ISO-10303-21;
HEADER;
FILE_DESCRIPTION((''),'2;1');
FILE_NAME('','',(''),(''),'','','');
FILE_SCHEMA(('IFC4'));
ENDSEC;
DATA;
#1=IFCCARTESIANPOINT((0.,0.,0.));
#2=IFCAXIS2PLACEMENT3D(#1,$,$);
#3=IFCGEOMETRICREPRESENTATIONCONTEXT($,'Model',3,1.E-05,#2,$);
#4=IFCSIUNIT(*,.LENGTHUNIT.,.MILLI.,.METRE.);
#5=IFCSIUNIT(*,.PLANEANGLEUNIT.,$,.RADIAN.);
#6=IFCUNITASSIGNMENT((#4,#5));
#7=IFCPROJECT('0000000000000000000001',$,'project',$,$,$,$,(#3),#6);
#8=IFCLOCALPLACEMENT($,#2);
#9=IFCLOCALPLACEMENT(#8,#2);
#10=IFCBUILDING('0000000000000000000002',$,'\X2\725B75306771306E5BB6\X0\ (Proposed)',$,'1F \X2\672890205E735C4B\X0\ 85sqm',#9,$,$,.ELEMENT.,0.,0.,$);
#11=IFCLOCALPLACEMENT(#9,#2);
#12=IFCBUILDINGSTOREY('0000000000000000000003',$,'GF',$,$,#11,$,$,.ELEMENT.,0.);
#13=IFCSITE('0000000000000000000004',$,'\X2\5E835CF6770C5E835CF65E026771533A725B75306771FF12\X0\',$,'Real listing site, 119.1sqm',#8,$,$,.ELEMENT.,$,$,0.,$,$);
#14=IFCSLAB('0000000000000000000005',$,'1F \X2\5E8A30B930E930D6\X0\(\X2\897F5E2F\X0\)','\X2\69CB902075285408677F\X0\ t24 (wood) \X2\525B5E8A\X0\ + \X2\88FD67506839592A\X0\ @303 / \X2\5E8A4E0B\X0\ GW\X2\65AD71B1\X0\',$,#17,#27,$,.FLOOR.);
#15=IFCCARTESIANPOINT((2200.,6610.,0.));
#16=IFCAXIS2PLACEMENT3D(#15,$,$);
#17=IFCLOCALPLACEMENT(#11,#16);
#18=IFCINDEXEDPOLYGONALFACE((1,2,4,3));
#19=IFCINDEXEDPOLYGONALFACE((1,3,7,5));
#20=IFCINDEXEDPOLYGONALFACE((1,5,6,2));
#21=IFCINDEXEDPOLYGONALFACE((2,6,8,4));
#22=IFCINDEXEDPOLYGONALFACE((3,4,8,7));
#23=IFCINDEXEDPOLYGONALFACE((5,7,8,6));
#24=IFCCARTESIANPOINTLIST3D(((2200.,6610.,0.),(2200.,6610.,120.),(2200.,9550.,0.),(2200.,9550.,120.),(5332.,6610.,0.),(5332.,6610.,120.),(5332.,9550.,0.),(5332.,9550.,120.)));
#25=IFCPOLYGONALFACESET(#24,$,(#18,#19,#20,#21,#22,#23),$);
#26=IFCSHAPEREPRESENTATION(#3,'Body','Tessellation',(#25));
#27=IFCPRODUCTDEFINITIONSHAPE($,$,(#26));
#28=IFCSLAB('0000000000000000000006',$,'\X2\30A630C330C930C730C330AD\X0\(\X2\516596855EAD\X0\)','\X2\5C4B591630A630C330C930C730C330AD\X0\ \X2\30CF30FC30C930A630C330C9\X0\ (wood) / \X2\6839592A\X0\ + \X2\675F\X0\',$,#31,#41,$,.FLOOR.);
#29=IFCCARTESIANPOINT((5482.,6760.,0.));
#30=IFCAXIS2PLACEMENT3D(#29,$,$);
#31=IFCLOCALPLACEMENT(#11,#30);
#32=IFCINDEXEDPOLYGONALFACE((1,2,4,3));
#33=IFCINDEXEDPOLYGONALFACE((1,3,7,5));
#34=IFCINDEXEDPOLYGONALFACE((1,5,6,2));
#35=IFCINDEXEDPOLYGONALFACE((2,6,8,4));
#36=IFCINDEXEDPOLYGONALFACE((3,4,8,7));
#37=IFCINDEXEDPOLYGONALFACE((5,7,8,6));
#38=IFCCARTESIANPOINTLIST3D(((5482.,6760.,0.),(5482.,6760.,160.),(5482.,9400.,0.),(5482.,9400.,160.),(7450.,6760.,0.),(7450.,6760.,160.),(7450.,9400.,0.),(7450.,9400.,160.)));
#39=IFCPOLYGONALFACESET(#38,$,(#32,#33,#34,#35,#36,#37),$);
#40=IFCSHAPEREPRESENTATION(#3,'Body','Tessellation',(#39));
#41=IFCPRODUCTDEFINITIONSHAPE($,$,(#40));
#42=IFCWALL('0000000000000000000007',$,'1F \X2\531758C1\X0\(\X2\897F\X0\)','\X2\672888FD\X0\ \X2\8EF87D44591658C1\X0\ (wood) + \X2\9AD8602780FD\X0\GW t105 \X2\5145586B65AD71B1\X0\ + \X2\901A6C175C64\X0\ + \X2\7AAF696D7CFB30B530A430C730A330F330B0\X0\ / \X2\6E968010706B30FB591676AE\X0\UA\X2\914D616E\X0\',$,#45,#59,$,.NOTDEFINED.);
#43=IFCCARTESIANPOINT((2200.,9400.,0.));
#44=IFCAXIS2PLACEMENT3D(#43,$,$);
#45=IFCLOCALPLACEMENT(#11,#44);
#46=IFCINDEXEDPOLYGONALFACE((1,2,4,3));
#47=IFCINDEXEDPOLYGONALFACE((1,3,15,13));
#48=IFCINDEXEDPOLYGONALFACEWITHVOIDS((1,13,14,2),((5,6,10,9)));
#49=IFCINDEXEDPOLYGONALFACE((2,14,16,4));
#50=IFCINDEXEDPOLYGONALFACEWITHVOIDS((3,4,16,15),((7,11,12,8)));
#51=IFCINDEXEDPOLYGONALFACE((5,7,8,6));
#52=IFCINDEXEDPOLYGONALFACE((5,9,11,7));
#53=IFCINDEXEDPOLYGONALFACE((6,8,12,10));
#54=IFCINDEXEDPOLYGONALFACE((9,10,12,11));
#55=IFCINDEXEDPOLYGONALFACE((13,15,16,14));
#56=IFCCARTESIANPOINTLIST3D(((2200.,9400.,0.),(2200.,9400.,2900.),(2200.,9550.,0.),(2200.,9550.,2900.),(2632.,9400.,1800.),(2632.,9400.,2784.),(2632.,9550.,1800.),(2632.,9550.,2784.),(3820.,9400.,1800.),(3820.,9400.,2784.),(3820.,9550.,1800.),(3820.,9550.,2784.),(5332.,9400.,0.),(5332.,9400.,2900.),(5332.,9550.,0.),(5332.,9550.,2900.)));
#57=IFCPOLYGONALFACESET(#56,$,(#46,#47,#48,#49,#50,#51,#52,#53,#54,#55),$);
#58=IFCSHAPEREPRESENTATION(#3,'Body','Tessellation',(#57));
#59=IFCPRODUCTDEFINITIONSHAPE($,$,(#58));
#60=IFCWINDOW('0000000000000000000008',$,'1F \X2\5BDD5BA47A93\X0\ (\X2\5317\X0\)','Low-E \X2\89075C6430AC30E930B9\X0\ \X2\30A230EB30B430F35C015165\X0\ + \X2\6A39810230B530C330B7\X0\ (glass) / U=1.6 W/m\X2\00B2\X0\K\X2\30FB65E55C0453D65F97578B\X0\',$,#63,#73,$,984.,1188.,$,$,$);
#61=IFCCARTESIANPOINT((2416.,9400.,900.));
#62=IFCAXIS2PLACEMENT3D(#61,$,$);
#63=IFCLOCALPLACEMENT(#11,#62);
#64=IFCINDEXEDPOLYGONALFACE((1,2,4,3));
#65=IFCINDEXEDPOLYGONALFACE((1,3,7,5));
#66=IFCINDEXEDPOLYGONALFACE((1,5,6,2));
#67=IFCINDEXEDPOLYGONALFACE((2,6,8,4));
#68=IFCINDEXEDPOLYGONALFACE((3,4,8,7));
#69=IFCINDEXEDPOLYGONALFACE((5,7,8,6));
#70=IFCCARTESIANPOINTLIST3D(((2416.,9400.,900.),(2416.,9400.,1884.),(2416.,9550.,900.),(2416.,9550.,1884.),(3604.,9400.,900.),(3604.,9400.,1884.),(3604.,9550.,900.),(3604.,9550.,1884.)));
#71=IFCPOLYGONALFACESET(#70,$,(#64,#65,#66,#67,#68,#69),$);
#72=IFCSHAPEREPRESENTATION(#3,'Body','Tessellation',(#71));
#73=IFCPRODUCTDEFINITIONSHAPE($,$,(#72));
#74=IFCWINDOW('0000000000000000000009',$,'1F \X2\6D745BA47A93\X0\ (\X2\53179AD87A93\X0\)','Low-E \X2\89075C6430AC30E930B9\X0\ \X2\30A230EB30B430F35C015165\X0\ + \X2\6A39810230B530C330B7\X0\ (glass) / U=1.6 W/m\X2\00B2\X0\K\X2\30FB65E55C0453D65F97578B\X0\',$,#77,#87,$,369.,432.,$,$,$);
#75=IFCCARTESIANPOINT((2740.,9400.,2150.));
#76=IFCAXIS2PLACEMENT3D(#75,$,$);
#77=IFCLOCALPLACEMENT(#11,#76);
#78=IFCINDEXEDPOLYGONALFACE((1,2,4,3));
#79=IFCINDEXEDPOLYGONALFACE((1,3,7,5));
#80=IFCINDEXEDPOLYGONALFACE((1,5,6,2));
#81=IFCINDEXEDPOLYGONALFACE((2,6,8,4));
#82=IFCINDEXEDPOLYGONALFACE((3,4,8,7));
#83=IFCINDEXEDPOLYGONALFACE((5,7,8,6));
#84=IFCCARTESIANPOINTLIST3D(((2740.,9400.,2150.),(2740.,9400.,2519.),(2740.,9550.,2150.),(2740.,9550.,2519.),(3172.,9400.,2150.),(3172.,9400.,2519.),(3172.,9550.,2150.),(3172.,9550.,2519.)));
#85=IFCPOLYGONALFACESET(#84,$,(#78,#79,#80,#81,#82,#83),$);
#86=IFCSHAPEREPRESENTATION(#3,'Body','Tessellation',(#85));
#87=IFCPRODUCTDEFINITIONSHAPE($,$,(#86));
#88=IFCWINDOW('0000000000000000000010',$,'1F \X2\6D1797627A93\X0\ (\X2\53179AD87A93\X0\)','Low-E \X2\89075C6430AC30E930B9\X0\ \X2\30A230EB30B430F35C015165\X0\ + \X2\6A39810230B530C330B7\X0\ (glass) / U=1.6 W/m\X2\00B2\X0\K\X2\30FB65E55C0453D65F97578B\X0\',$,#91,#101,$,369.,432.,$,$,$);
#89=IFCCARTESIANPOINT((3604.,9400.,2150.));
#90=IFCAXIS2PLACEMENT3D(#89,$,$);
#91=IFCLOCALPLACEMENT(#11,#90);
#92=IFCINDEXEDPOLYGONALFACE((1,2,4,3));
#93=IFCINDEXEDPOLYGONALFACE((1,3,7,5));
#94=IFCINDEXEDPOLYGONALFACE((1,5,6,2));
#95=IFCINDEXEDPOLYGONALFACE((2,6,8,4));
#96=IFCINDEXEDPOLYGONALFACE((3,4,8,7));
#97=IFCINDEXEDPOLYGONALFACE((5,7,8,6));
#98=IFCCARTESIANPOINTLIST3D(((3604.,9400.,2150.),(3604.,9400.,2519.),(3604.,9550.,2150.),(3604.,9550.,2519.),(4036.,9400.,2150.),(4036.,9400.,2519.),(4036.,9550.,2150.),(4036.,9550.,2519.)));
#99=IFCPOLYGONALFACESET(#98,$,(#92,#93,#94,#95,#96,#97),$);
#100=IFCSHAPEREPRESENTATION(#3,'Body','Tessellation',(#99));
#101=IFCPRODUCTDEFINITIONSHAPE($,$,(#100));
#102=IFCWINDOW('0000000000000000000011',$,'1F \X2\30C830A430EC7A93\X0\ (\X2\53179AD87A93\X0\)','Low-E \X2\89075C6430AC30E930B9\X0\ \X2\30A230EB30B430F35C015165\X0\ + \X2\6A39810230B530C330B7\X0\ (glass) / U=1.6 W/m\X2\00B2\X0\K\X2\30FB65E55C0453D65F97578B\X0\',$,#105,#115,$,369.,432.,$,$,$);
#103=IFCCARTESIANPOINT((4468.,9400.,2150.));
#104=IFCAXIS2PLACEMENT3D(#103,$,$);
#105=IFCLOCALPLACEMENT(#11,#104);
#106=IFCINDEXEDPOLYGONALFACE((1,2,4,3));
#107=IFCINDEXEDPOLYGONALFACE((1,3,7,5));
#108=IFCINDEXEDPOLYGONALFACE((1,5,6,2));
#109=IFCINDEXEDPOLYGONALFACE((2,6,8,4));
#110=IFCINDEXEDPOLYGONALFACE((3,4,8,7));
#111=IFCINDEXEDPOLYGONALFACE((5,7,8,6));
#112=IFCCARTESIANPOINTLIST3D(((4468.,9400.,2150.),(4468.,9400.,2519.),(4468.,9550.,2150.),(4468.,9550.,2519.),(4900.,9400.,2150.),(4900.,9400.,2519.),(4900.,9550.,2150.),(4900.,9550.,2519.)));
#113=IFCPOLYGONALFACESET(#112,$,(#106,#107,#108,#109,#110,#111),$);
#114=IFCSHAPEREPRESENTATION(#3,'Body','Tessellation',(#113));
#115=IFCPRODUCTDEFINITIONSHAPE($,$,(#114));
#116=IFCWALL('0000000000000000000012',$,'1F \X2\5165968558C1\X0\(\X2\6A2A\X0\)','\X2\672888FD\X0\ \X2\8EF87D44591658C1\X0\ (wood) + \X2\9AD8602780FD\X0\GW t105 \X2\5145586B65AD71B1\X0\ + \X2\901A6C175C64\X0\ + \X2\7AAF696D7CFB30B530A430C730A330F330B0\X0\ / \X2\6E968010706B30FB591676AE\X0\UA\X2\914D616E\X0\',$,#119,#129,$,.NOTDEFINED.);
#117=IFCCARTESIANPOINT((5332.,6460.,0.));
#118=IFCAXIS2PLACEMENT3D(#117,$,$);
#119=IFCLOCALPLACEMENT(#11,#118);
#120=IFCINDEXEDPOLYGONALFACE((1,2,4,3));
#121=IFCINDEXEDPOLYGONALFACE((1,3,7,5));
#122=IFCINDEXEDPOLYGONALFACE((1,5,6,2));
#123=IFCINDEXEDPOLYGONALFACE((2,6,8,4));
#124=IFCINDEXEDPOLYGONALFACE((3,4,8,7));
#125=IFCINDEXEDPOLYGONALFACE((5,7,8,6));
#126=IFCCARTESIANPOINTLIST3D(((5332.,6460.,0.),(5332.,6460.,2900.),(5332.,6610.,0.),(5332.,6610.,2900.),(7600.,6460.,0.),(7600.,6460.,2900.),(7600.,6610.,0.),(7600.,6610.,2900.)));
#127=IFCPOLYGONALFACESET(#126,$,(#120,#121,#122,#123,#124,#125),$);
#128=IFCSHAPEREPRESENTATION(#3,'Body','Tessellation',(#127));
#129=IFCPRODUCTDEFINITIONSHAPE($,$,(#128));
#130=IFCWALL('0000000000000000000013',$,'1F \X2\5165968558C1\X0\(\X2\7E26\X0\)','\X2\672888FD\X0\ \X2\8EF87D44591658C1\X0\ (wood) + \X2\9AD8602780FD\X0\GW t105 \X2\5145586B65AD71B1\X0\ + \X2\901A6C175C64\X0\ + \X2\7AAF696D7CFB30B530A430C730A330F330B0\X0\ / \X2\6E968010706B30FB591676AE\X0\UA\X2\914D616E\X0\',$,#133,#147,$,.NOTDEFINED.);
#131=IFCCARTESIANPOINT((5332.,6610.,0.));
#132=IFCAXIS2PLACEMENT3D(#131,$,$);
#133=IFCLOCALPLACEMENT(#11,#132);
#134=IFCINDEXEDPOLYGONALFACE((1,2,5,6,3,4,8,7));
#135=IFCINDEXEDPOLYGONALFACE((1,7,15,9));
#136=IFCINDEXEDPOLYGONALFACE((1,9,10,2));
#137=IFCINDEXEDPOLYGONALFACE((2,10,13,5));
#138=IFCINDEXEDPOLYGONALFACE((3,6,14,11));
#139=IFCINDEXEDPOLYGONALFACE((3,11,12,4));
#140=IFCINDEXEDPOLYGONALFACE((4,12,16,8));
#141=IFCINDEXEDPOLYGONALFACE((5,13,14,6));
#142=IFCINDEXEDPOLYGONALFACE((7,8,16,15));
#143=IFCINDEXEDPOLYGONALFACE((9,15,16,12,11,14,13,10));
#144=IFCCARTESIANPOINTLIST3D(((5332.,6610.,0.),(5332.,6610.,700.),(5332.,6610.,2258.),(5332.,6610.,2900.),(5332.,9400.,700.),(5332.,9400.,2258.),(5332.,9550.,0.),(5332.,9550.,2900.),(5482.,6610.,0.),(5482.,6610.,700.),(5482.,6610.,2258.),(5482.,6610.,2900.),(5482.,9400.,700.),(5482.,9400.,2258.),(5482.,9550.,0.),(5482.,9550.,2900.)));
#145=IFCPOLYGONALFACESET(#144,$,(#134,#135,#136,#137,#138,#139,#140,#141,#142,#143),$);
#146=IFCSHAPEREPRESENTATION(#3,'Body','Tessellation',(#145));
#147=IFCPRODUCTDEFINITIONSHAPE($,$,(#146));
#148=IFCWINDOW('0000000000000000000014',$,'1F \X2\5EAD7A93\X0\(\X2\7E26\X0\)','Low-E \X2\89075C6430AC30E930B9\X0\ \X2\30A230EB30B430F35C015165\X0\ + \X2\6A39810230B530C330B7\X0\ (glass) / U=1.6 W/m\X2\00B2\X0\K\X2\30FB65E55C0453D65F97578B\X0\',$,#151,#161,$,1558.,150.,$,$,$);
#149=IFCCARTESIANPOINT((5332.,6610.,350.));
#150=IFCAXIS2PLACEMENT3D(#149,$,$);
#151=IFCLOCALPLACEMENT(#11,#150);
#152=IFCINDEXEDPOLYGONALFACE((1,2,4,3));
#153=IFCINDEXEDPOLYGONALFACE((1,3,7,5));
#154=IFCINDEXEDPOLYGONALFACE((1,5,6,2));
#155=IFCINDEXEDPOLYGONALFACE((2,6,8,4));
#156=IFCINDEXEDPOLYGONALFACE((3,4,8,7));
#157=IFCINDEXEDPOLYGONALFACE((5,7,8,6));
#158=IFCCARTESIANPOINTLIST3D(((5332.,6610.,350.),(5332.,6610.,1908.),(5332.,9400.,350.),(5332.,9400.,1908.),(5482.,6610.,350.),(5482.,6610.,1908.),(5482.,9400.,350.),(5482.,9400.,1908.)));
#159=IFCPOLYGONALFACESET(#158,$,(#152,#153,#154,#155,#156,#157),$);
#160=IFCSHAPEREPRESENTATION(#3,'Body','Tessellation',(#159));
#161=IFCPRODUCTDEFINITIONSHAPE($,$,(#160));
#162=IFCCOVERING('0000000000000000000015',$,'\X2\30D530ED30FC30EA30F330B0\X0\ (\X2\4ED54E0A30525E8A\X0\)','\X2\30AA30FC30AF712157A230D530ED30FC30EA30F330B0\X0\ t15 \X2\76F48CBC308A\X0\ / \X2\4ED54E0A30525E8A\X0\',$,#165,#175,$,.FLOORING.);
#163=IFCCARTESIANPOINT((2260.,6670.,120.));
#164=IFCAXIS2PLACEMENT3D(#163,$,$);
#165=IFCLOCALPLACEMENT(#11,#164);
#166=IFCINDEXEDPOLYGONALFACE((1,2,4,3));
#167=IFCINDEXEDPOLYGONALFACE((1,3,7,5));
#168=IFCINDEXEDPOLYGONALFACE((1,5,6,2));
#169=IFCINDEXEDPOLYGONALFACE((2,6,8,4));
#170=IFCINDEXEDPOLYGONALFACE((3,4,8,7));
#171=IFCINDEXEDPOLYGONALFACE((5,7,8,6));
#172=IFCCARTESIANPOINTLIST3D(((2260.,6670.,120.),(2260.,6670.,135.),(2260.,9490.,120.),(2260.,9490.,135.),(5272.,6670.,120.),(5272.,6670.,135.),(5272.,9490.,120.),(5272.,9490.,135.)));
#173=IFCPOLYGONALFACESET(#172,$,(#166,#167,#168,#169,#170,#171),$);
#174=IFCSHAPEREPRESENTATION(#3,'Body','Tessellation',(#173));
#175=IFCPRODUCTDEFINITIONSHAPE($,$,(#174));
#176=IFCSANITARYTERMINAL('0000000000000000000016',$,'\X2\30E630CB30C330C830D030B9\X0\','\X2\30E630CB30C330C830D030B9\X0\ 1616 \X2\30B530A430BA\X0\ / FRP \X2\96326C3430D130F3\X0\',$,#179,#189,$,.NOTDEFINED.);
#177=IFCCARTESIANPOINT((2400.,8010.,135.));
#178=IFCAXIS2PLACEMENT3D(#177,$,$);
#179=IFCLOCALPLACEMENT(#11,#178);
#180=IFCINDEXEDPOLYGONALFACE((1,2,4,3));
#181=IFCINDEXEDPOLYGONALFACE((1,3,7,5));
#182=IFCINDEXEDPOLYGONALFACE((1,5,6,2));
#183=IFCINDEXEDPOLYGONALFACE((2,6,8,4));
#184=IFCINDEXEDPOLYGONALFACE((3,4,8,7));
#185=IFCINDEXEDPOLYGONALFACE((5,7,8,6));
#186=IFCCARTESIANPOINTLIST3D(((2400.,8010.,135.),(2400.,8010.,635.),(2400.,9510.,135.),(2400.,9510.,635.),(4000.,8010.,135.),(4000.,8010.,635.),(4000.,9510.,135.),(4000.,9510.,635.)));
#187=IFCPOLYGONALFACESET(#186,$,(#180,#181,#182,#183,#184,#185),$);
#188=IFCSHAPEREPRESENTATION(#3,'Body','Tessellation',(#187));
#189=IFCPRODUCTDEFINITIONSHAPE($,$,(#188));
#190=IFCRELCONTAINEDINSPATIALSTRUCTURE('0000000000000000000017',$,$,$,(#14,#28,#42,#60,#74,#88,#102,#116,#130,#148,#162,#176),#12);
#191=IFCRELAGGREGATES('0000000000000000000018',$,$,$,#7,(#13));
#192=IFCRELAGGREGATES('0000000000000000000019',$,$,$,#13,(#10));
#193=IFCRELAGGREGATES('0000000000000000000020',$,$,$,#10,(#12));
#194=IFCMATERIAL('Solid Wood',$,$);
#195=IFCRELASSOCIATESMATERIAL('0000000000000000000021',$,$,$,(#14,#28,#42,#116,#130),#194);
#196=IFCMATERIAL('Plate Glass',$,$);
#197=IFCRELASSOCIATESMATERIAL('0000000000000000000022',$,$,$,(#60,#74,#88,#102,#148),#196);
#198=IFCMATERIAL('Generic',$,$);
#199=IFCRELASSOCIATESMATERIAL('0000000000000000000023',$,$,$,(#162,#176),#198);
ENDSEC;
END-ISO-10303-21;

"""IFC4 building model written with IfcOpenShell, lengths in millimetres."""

from ifc_helpers import new_model, si_unit, frame, frame_2d, origin, place, context, project, spatial, rectangle, extrude, material, element, fill, save


model = new_model("IFC4")

# Units and contexts
model_context = context("Model", 3, precision=1e-05, world=origin())
ifc_project = project(units=[si_unit("LENGTHUNIT", "METRE", prefix="MILLI"), si_unit("PLANEANGLEUNIT", "RADIAN")], contexts=[model_context])

# Site, building, storey
site_placement = place(None, origin())
site = spatial("IfcSite", under=ifc_project, at=site_placement, Name="広島県広島市東区牛田東２", ObjectType="Real listing site, 119.1sqm", CompositionType="ELEMENT", RefElevation=0.0)
building_placement = place(site_placement, origin())
building = spatial("IfcBuilding", under=site, at=building_placement, Name="牛田東の家 (Proposed)", ObjectType="1F 木造平屋 85sqm", CompositionType="ELEMENT", ElevationOfRefHeight=0.0, ElevationOfTerrain=0.0)
storey_placement = place(building_placement, origin())
storey = spatial("IfcBuildingStorey", under=building, at=storey_placement, Name="GF", CompositionType="ELEMENT", Elevation=0.0)

# Slabs
ifc_material_1 = material(Name="Solid Wood")
slab_1_placement = place(storey_placement, frame((2200.0, 6610.0, 0.0)))
element("IfcSlab", 1, at=slab_1_placement, inside=storey, material=ifc_material_1, Name="1F 床スラブ(西帯)", Description="構造用合板 t24 (wood) 剛床 + 製材根太 @303 / 床下 GW断熱", PredefinedType="FLOOR", context=model_context, shape_type="SweptSolid", body=[
    extrude(rectangle(XDim=3132.0, YDim=2940.0, at=frame_2d((1566.0, 1470.0))), frame((2200.0, 6610.0, 0.0)), (0.0, 0.0, 1.0), 120.0),
])
slab_2_placement = place(storey_placement, frame((5482.0, 6760.0, 0.0)))
element("IfcSlab", 2, at=slab_2_placement, inside=storey, material=ifc_material_1, Name="ウッドデッキ(入隅庭)", Description="屋外ウッドデッキ ハードウッド (wood) / 根太 + 束", PredefinedType="FLOOR", context=model_context, shape_type="SweptSolid", body=[
    extrude(rectangle(XDim=1968.0, YDim=2640.0, at=frame_2d((984.0, 1320.0))), frame((5482.0, 6760.0, 0.0)), (0.0, 0.0, 1.0), 160.0),
])

# Wall, openings, windows
wall_1_placement = place(storey_placement, frame((2200.0, 9400.0, 0.0)))
wall_1 = element("IfcWall", 3, at=wall_1_placement, inside=storey, material=ifc_material_1, Name="1F 北壁(西)", Description="木製 軸組外壁 (wood) + 高性能GW t105 充填断熱 + 通気層 + 窯業系サイディング / 準耐火・外皮UA配慮", PredefinedType="NOTDEFINED", context=model_context, shape_type="SweptSolid", body=[
    extrude(rectangle(XDim=3132.0, YDim=150.0, at=frame_2d((1566.0, 75.0))), frame((2200.0, 9400.0, 0.0)), (0.0, 0.0, 1.0), 2900.0),
])
opening_1_placement = place(storey_placement, frame((2416.0, 9400.0, 900.0)))
opening_1 = element("IfcOpeningElement", 4, at=opening_1_placement, cuts=wall_1, PredefinedType="NOTDEFINED", context=model_context, shape_type="SweptSolid", body=[
    extrude(rectangle(XDim=1188.0, YDim=150.0, at=frame_2d((594.0, 75.0))), frame((2416.0, 9400.0, 900.0)), (0.0, 0.0, 1.0), 984.0),
])
opening_2_placement = place(storey_placement, frame((2740.0, 9400.0, 2150.0)))
opening_2 = element("IfcOpeningElement", 5, at=opening_2_placement, cuts=wall_1, PredefinedType="NOTDEFINED", context=model_context, shape_type="SweptSolid", body=[
    extrude(rectangle(XDim=432.0, YDim=150.0, at=frame_2d((216.0, 75.0))), frame((2740.0, 9400.0, 2150.0)), (0.0, 0.0, 1.0), 369.0),
])
opening_3_placement = place(storey_placement, frame((3604.0, 9400.0, 2150.0)))
opening_3 = element("IfcOpeningElement", 6, at=opening_3_placement, cuts=wall_1, PredefinedType="NOTDEFINED", context=model_context, shape_type="SweptSolid", body=[
    extrude(rectangle(XDim=432.0, YDim=150.0, at=frame_2d((216.0, 75.0))), frame((3604.0, 9400.0, 2150.0)), (0.0, 0.0, 1.0), 369.0),
])
opening_4_placement = place(storey_placement, frame((4468.0, 9400.0, 2150.0)))
opening_4 = element("IfcOpeningElement", 7, at=opening_4_placement, cuts=wall_1, PredefinedType="NOTDEFINED", context=model_context, shape_type="SweptSolid", body=[
    extrude(rectangle(XDim=432.0, YDim=150.0, at=frame_2d((216.0, 75.0))), frame((4468.0, 9400.0, 2150.0)), (0.0, 0.0, 1.0), 369.0),
])
ifc_material_2 = material(Name="Plate Glass")
window_1_placement = place(storey_placement, frame((2416.0, 9400.0, 900.0)))
window_1 = element("IfcWindow", 8, at=window_1_placement, inside=storey, material=ifc_material_2, Name="1F 寝室窓 (北)", Description="Low-E 複層ガラス アルゴン封入 + 樹脂サッシ (glass) / U=1.6 W/m²K・日射取得型", OverallHeight=984.0, OverallWidth=1188.0, context=model_context, shape_type="SweptSolid", body=[
    extrude(rectangle(XDim=1188.0, YDim=150.0, at=frame_2d((594.0, 75.0))), frame((2416.0, 9400.0, 900.0)), (0.0, 0.0, 1.0), 984.0),
])
fill(opening_1, window_1)
window_2_placement = place(storey_placement, frame((2740.0, 9400.0, 2150.0)))
window_2 = element("IfcWindow", 9, at=window_2_placement, inside=storey, material=ifc_material_2, Name="1F 浴室窓 (北高窓)", Description="Low-E 複層ガラス アルゴン封入 + 樹脂サッシ (glass) / U=1.6 W/m²K・日射取得型", OverallHeight=369.0, OverallWidth=432.0, context=model_context, shape_type="SweptSolid", body=[
    extrude(rectangle(XDim=432.0, YDim=150.0, at=frame_2d((216.0, 75.0))), frame((2740.0, 9400.0, 2150.0)), (0.0, 0.0, 1.0), 369.0),
])
fill(opening_2, window_2)
window_3_placement = place(storey_placement, frame((3604.0, 9400.0, 2150.0)))
window_3 = element("IfcWindow", 10, at=window_3_placement, inside=storey, material=ifc_material_2, Name="1F 洗面窓 (北高窓)", Description="Low-E 複層ガラス アルゴン封入 + 樹脂サッシ (glass) / U=1.6 W/m²K・日射取得型", OverallHeight=369.0, OverallWidth=432.0, context=model_context, shape_type="SweptSolid", body=[
    extrude(rectangle(XDim=432.0, YDim=150.0, at=frame_2d((216.0, 75.0))), frame((3604.0, 9400.0, 2150.0)), (0.0, 0.0, 1.0), 369.0),
])
fill(opening_3, window_3)
window_4_placement = place(storey_placement, frame((4468.0, 9400.0, 2150.0)))
window_4 = element("IfcWindow", 11, at=window_4_placement, inside=storey, material=ifc_material_2, Name="1F トイレ窓 (北高窓)", Description="Low-E 複層ガラス アルゴン封入 + 樹脂サッシ (glass) / U=1.6 W/m²K・日射取得型", OverallHeight=369.0, OverallWidth=432.0, context=model_context, shape_type="SweptSolid", body=[
    extrude(rectangle(XDim=432.0, YDim=150.0, at=frame_2d((216.0, 75.0))), frame((4468.0, 9400.0, 2150.0)), (0.0, 0.0, 1.0), 369.0),
])
fill(opening_4, window_4)

# Wall
wall_2_placement = place(storey_placement, frame((5332.0, 6460.0, 0.0)))
element("IfcWall", 12, at=wall_2_placement, inside=storey, material=ifc_material_1, Name="1F 入隅壁(横)", Description="木製 軸組外壁 (wood) + 高性能GW t105 充填断熱 + 通気層 + 窯業系サイディング / 準耐火・外皮UA配慮", PredefinedType="NOTDEFINED", context=model_context, shape_type="SweptSolid", body=[
    extrude(rectangle(XDim=2268.0, YDim=150.0, at=frame_2d((1134.0, 75.0))), frame((5332.0, 6460.0, 0.0)), (0.0, 0.0, 1.0), 2900.0),
])

# Wall, opening, window
wall_3_placement = place(storey_placement, frame((5332.0, 6610.0, 0.0)))
wall_3 = element("IfcWall", 13, at=wall_3_placement, inside=storey, material=ifc_material_1, Name="1F 入隅壁(縦)", Description="木製 軸組外壁 (wood) + 高性能GW t105 充填断熱 + 通気層 + 窯業系サイディング / 準耐火・外皮UA配慮", PredefinedType="NOTDEFINED", context=model_context, shape_type="SweptSolid", body=[
    extrude(rectangle(XDim=150.0, YDim=2940.0, at=frame_2d((75.0, 1470.0))), frame((5332.0, 6610.0, 0.0)), (0.0, 0.0, 1.0), 2900.0),
])
opening_5_placement = place(storey_placement, frame((5332.0, 6610.0, 350.0)))
opening_5 = element("IfcOpeningElement", 14, at=opening_5_placement, cuts=wall_3, PredefinedType="NOTDEFINED", context=model_context, shape_type="SweptSolid", body=[
    extrude(rectangle(XDim=150.0, YDim=2790.0, at=frame_2d((75.0, 1395.0))), frame((5332.0, 6610.0, 350.0)), (0.0, 0.0, 1.0), 1558.0),
])
window_5_placement = place(storey_placement, frame((5332.0, 6610.0, 350.0)))
window_5 = element("IfcWindow", 15, at=window_5_placement, inside=storey, material=ifc_material_2, Name="1F 庭窓(縦)", Description="Low-E 複層ガラス アルゴン封入 + 樹脂サッシ (glass) / U=1.6 W/m²K・日射取得型", OverallHeight=1558.0, OverallWidth=150.0, context=model_context, shape_type="SweptSolid", body=[
    extrude(rectangle(XDim=150.0, YDim=2790.0, at=frame_2d((75.0, 1395.0))), frame((5332.0, 6610.0, 350.0)), (0.0, 0.0, 1.0), 1558.0),
])
fill(opening_5, window_5)

# Covering
ifc_material_3 = material(Name="Generic")
covering_placement = place(storey_placement, frame((2260.0, 6670.0, 120.0)))
element("IfcCovering", 16, at=covering_placement, inside=storey, material=ifc_material_3, Name="フローリング (仕上げ床)", Description="オーク無垢フローリング t15 直貼り / 仕上げ床", PredefinedType="FLOORING", context=model_context, shape_type="SweptSolid", body=[
    extrude(rectangle(XDim=3012.0, YDim=2820.0, at=frame_2d((1506.0, 1410.0))), frame((2260.0, 6670.0, 120.0)), (0.0, 0.0, 1.0), 15.0),
])

# Sanitary terminal
sanitary_terminal_1_placement = place(storey_placement, frame((2400.0, 8010.0, 135.0)))
element("IfcSanitaryTerminal", 17, at=sanitary_terminal_1_placement, inside=storey, material=ifc_material_3, Name="ユニットバス", Description="ユニットバス 1616 サイズ / FRP 防水パン", PredefinedType="NOTDEFINED", context=model_context, shape_type="SweptSolid", body=[
    extrude(rectangle(XDim=1600.0, YDim=1500.0, at=frame_2d((800.0, 750.0))), frame((2400.0, 8010.0, 135.0)), (0.0, 0.0, 1.0), 500.0),
])

save(model, "model.ifc")
